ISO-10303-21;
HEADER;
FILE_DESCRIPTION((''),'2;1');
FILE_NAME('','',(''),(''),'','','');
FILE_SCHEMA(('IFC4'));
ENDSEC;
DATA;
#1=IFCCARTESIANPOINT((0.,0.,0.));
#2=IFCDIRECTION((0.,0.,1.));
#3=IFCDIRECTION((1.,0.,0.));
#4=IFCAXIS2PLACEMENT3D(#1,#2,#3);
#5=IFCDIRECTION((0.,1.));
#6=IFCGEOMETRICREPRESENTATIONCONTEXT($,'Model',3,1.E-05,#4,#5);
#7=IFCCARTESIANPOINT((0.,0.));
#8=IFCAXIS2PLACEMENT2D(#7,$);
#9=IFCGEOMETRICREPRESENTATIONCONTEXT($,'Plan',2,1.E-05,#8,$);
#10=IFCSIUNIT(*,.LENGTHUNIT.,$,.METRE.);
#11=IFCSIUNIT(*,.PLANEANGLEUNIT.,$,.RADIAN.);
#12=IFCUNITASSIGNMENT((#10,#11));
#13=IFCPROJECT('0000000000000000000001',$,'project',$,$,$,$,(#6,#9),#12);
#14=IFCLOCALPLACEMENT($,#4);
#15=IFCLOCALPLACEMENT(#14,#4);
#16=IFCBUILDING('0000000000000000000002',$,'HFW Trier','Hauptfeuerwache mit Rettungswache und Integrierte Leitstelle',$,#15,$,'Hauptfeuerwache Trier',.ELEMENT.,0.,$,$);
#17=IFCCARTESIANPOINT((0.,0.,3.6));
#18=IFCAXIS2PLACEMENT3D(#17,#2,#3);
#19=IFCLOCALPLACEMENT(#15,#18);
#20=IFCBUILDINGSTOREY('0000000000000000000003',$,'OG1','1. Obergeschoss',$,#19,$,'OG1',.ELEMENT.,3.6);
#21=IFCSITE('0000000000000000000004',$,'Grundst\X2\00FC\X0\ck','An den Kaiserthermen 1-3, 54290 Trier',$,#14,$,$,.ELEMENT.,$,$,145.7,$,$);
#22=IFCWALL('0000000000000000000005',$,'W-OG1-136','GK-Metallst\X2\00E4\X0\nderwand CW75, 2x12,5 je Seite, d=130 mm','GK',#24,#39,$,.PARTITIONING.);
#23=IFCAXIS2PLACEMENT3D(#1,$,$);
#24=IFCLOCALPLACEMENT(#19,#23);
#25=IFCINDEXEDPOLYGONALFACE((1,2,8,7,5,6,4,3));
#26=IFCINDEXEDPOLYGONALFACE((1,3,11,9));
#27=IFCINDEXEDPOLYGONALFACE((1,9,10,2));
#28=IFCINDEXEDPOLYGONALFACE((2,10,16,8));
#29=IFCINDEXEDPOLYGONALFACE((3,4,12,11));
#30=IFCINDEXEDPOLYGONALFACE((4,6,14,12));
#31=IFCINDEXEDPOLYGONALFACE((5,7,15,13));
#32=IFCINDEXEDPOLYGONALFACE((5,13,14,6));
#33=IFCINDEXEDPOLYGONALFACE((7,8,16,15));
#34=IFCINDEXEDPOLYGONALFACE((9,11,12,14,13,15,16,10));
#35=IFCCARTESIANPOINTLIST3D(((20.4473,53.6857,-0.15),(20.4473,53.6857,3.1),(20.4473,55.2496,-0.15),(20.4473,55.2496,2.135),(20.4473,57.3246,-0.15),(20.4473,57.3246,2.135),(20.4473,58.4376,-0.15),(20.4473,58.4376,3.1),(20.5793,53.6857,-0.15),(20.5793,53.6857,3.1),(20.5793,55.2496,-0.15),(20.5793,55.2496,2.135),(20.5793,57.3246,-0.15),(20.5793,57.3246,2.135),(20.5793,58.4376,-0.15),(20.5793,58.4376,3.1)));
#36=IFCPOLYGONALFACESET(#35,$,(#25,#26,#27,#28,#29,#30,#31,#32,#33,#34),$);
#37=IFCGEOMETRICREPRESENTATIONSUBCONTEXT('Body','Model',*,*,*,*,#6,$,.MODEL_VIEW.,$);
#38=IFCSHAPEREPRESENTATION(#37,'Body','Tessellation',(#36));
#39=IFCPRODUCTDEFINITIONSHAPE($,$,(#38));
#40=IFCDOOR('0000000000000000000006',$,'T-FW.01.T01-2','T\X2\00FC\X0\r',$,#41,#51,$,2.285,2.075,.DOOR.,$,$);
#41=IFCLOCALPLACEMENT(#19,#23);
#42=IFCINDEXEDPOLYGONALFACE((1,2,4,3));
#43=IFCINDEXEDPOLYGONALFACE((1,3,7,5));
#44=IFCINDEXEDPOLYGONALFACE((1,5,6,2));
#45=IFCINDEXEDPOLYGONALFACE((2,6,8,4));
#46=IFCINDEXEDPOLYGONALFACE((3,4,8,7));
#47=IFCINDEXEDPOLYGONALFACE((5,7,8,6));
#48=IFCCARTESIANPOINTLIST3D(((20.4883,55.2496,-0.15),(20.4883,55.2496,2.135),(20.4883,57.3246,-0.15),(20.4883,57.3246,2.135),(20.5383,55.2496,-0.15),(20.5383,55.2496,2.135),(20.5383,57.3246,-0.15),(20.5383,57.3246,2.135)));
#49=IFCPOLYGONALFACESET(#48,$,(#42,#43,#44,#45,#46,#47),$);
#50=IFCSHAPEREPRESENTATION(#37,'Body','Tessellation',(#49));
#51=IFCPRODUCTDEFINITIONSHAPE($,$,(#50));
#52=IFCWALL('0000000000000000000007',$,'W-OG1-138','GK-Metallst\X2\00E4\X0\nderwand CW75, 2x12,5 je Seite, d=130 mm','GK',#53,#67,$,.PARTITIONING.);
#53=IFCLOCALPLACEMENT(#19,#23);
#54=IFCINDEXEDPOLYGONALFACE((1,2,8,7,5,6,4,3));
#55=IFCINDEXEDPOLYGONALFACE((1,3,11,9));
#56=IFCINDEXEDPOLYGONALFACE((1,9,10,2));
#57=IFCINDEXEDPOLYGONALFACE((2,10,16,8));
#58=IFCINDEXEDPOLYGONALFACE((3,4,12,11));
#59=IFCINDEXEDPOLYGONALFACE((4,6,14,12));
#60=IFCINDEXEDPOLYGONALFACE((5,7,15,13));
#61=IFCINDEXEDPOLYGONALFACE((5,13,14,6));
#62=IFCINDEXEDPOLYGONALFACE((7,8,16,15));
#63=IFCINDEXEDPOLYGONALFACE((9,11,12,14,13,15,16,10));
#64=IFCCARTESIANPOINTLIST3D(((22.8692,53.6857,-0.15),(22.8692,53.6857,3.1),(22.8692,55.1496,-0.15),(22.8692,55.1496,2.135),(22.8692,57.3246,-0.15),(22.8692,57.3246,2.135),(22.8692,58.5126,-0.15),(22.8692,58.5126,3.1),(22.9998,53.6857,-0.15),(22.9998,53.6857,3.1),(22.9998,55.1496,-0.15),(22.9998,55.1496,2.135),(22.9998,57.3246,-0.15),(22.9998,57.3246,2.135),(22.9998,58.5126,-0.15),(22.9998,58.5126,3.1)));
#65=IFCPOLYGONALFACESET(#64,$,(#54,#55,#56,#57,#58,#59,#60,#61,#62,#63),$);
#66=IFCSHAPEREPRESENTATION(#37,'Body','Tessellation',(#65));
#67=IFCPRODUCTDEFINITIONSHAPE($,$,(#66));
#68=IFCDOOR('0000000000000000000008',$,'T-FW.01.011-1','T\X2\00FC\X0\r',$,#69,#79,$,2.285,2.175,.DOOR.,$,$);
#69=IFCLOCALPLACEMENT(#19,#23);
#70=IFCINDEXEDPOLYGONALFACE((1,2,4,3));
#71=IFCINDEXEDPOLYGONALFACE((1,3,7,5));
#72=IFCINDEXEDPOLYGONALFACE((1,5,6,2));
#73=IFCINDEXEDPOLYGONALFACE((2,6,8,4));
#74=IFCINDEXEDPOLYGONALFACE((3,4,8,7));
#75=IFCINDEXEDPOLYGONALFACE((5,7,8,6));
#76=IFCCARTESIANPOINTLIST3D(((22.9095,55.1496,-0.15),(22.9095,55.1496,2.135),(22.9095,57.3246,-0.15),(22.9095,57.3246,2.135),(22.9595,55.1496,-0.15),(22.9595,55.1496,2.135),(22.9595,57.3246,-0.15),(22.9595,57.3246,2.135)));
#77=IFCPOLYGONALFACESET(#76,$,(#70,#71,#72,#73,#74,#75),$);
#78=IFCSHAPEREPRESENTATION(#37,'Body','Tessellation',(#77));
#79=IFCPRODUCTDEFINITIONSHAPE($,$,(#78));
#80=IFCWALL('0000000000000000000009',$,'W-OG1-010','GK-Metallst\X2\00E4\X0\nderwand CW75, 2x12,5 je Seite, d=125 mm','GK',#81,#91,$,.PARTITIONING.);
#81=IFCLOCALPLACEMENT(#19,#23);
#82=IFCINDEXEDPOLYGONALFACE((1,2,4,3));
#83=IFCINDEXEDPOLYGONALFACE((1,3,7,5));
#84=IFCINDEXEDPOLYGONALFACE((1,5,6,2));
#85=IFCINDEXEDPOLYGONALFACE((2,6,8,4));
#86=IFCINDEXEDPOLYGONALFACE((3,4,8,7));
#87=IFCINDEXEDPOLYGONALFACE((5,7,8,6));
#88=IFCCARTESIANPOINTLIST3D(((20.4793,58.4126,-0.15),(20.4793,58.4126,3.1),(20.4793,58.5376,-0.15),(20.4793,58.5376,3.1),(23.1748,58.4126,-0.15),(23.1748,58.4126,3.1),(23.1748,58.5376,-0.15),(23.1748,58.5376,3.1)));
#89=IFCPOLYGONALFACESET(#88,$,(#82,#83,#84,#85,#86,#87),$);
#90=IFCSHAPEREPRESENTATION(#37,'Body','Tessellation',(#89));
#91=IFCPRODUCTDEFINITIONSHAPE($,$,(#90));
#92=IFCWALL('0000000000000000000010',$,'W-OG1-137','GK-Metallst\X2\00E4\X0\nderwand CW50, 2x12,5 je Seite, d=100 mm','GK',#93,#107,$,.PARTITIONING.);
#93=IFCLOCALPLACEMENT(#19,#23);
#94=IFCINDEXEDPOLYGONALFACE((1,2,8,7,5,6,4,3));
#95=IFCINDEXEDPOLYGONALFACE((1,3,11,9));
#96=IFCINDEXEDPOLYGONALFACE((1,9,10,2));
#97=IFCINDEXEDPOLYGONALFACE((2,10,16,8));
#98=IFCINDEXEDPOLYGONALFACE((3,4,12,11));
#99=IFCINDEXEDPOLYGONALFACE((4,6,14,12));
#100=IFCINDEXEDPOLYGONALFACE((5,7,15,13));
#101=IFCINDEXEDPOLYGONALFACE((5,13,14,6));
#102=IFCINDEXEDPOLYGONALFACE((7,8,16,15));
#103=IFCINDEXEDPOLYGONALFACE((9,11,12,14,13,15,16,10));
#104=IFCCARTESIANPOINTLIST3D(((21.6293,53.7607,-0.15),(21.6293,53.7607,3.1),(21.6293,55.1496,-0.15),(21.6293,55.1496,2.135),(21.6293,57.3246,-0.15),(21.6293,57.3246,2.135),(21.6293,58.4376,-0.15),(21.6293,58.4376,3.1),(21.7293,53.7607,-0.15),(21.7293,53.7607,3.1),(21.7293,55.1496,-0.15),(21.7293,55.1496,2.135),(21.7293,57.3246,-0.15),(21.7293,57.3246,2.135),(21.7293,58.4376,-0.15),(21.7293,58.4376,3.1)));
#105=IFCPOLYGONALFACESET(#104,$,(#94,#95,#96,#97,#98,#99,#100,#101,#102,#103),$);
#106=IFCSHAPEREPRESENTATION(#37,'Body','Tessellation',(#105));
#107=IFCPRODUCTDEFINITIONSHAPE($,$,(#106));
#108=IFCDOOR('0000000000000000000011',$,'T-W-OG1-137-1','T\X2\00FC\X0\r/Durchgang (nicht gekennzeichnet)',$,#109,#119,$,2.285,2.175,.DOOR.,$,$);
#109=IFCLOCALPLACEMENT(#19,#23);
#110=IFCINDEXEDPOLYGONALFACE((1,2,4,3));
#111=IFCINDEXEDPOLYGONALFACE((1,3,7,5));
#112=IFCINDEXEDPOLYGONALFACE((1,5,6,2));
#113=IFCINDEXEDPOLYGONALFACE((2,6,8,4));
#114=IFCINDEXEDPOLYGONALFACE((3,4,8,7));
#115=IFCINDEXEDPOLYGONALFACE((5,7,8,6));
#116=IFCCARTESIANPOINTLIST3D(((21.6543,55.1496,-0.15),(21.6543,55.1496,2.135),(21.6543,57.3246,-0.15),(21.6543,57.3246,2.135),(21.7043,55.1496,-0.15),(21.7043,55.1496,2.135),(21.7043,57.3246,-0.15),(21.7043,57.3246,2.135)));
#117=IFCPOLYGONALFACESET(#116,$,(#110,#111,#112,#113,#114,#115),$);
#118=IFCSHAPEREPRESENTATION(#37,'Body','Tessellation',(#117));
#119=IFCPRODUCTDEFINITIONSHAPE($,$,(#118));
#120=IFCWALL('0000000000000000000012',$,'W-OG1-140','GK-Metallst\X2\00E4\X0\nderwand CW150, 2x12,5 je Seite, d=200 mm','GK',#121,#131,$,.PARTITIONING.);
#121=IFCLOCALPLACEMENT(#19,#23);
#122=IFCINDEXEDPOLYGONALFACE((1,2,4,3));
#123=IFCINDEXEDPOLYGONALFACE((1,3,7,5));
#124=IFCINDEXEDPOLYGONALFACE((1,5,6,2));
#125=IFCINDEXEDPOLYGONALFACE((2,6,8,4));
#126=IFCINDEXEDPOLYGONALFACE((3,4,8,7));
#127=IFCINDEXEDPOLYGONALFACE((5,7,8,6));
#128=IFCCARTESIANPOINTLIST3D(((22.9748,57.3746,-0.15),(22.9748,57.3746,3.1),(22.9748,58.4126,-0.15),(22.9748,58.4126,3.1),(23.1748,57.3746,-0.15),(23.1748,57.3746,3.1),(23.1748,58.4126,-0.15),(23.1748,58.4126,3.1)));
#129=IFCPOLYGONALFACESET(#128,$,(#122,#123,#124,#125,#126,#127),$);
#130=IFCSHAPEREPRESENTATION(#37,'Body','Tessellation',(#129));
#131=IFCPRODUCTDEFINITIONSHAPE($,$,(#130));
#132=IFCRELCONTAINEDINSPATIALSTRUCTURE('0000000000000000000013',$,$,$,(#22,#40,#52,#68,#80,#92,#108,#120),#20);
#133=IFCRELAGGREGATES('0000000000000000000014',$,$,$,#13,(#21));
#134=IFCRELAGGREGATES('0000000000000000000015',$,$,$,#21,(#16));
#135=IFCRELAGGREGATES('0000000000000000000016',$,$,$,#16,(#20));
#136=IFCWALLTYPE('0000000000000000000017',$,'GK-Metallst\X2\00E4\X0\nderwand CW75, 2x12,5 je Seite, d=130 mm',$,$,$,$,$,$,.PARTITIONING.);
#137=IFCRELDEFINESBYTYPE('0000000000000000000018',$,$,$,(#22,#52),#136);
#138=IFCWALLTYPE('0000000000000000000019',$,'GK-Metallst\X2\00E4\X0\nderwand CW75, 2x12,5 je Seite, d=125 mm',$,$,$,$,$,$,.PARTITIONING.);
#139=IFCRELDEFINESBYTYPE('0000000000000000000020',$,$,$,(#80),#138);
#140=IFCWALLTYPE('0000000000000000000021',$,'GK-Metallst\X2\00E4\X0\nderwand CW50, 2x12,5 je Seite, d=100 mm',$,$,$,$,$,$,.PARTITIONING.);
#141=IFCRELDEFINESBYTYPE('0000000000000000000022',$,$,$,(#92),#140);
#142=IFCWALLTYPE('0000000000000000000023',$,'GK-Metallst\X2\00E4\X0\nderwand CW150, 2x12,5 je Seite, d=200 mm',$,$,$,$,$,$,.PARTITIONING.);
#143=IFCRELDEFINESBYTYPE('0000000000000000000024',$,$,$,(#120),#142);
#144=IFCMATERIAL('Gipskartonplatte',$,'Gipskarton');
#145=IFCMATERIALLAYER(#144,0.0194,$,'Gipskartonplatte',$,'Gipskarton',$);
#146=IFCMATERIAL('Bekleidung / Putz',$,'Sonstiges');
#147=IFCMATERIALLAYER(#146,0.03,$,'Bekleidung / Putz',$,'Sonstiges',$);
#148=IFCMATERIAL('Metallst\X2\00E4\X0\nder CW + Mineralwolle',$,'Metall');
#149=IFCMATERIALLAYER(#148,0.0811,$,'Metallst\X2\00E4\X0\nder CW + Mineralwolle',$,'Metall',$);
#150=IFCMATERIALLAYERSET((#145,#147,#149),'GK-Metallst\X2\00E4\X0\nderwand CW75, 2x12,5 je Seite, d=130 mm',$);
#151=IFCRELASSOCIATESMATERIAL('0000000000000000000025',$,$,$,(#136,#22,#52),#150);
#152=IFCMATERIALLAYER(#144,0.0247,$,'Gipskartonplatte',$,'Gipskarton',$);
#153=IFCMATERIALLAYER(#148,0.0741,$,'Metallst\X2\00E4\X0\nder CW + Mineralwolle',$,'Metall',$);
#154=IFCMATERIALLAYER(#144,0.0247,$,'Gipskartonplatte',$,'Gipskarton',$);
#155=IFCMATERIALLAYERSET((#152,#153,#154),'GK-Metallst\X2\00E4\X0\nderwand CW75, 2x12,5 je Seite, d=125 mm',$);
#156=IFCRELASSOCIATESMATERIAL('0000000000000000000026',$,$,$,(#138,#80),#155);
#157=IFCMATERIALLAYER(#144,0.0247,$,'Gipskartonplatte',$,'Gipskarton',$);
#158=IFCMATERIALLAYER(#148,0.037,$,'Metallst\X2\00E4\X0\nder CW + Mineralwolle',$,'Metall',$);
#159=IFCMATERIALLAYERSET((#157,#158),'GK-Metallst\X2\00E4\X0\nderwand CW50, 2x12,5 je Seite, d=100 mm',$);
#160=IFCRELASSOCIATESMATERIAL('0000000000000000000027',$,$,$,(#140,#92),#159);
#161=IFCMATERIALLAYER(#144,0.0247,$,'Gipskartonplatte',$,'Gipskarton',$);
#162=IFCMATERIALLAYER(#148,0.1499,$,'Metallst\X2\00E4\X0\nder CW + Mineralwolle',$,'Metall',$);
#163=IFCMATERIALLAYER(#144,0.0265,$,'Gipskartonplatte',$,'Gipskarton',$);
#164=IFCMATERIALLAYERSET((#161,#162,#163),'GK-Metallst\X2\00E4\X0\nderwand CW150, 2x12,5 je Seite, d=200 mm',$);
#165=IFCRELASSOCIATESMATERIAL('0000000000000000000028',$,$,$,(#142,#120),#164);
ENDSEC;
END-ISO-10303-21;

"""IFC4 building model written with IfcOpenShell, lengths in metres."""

from ifc_helpers import new_model, si_unit, direction, frame, frame_2d, origin_with_axes, origin_2d, place, context, subcontext, project, spatial, rectangle, extrude, material, layer, layer_set, layer_usage, type_object, element, fill, save


model = new_model("IFC4")

# Units and contexts
model_context = context("Model", 3, precision=1e-05, world=origin_with_axes(), true_north=direction((0.0, 1.0)))
plan_context = context("Plan", 2, precision=1e-05, world=origin_2d())
body_context = subcontext(model_context, "Body", "Model", "MODEL_VIEW")
ifc_project = project(units=[si_unit("LENGTHUNIT", "METRE"), si_unit("PLANEANGLEUNIT", "RADIAN")], contexts=[model_context, plan_context])

# Site, building, storey
site_placement = place(None, origin_with_axes())
site = spatial("IfcSite", under=ifc_project, at=site_placement, Name="Grundstück", Description="An den Kaiserthermen 1-3, 54290 Trier", CompositionType="ELEMENT", RefElevation=145.7)
building_placement = place(site_placement, origin_with_axes())
building = spatial("IfcBuilding", under=site, at=building_placement, Name="HFW Trier", Description="Hauptfeuerwache mit Rettungswache und Integrierte Leitstelle", LongName="Hauptfeuerwache Trier", CompositionType="ELEMENT", ElevationOfRefHeight=0.0)
storey_placement = place(building_placement, frame((0.0, 0.0, 3.6), z_axis=(0.0, 0.0, 1.0), x_axis=(1.0, 0.0, 0.0)))
storey = spatial("IfcBuildingStorey", under=building, at=storey_placement, Name="OG1", Description="1. Obergeschoss", LongName="OG1", CompositionType="ELEMENT", Elevation=3.6)

# Walls, openings, doors
ifc_material_1 = material(Name="Gipskartonplatte", Category="Gipskarton")
ifc_layer_1 = layer(ifc_material_1, 0.0194, Name="Gipskartonplatte", Category="Gipskarton")
ifc_material_2 = material(Name="Bekleidung / Putz", Category="Sonstiges")
ifc_layer_2 = layer(ifc_material_2, 0.03, Name="Bekleidung / Putz", Category="Sonstiges")
ifc_material_3 = material(Name="Metallständer CW + Mineralwolle", Category="Metall")
ifc_layer_3 = layer(ifc_material_3, 0.0811, Name="Metallständer CW + Mineralwolle", Category="Metall")
ifc_layer_set_1 = layer_set([ifc_layer_1, ifc_layer_2, ifc_layer_3], Name="GK-Metallständerwand CW75, 2x12,5 je Seite, d=130 mm")
ifc_layer_usage_1 = layer_usage(ifc_layer_set_1, "AXIS2", "POSITIVE", -0.066)
wall_type_1 = type_object("IfcWallType", Name="GK-Metallständerwand CW75, 2x12,5 je Seite, d=130 mm", PredefinedType="PARTITIONING", material=ifc_layer_set_1)
wall_1_placement = place(storey_placement, frame((20.5133, 58.4376, -0.15), z_axis=(0.0, 0.0, 1.0), x_axis=(0.0, -1.0, 0.0)))
wall_1 = element("IfcWall", 1, at=wall_1_placement, inside=storey, type_object=wall_type_1, material=ifc_layer_usage_1, Name="W-OG1-136", Description="GK-Metallständerwand CW75, 2x12,5 je Seite, d=130 mm", ObjectType="GK", PredefinedType="PARTITIONING", context=body_context, shape_type="SweptSolid", body=[
    extrude(rectangle(XDim=4.7519, YDim=0.132, at=frame_2d((2.376, 0.0))), origin_with_axes(), (0.0, 0.0, 1.0), 3.25),
])
opening_1_placement = place(wall_1_placement, frame((1.113, 0.0, 0.0), z_axis=(0.0, 0.0, 1.0), x_axis=(1.0, 0.0, 0.0)))
opening_1 = element("IfcOpeningElement", 2, at=opening_1_placement, cuts=wall_1, PredefinedType="OPENING", context=body_context, shape_type="SweptSolid", body=[
    extrude(rectangle(XDim=2.075, YDim=0.232, at=frame_2d((1.0375, 0.0))), origin_with_axes(), (0.0, 0.0, 1.0), 2.285),
])
door_1_placement = place(wall_1_placement, frame((1.113, 0.0, 0.0), z_axis=(0.0, 0.0, 1.0), x_axis=(1.0, 0.0, 0.0)))
door_1 = element("IfcDoor", 3, at=door_1_placement, inside=storey, Name="T-FW.01.T01-2", Description="Tür", OverallHeight=2.285, OverallWidth=2.075, PredefinedType="DOOR", context=body_context, shape_type="SweptSolid", body=[
    extrude(rectangle(XDim=2.075, YDim=0.05, at=frame_2d((1.0375, 0.0))), origin_with_axes(), (0.0, 0.0, 1.0), 2.285),
])
fill(opening_1, door_1)
ifc_layer_usage_2 = layer_usage(ifc_layer_set_1, "AXIS2", "POSITIVE", -0.0653)
wall_2_placement = place(storey_placement, frame((22.9345, 58.5126, -0.15), z_axis=(0.0, 0.0, 1.0), x_axis=(0.0, -1.0, 0.0)))
wall_2 = element("IfcWall", 4, at=wall_2_placement, inside=storey, type_object=wall_type_1, material=ifc_layer_usage_2, Name="W-OG1-138", Description="GK-Metallständerwand CW75, 2x12,5 je Seite, d=130 mm", ObjectType="GK", PredefinedType="PARTITIONING", context=body_context, shape_type="SweptSolid", body=[
    extrude(rectangle(XDim=4.8269, YDim=0.1305, at=frame_2d((2.4135, 0.0))), origin_with_axes(), (0.0, 0.0, 1.0), 3.25),
])
opening_2_placement = place(wall_2_placement, frame((1.188, 0.0, 0.0), z_axis=(0.0, 0.0, 1.0), x_axis=(1.0, 0.0, 0.0)))
opening_2 = element("IfcOpeningElement", 5, at=opening_2_placement, cuts=wall_2, PredefinedType="OPENING", context=body_context, shape_type="SweptSolid", body=[
    extrude(rectangle(XDim=2.175, YDim=0.2305, at=frame_2d((1.0875, 0.0))), origin_with_axes(), (0.0, 0.0, 1.0), 2.285),
])
door_2_placement = place(wall_2_placement, frame((1.188, 0.0, 0.0), z_axis=(0.0, 0.0, 1.0), x_axis=(1.0, 0.0, 0.0)))
door_2 = element("IfcDoor", 6, at=door_2_placement, inside=storey, Name="T-FW.01.011-1", Description="Tür", OverallHeight=2.285, OverallWidth=2.175, PredefinedType="DOOR", context=body_context, shape_type="SweptSolid", body=[
    extrude(rectangle(XDim=2.175, YDim=0.05, at=frame_2d((1.0875, 0.0))), origin_with_axes(), (0.0, 0.0, 1.0), 2.285),
])
fill(opening_2, door_2)

# Wall
ifc_layer_4 = layer(ifc_material_1, 0.0247, Name="Gipskartonplatte", Category="Gipskarton")
ifc_layer_5 = layer(ifc_material_3, 0.0741, Name="Metallständer CW + Mineralwolle", Category="Metall")
ifc_layer_6 = layer(ifc_material_1, 0.0247, Name="Gipskartonplatte", Category="Gipskarton")
ifc_layer_set_2 = layer_set([ifc_layer_4, ifc_layer_5, ifc_layer_6], Name="GK-Metallständerwand CW75, 2x12,5 je Seite, d=125 mm")
ifc_layer_usage_3 = layer_usage(ifc_layer_set_2, "AXIS2", "POSITIVE", -0.0625)
wall_type_2 = type_object("IfcWallType", Name="GK-Metallständerwand CW75, 2x12,5 je Seite, d=125 mm", PredefinedType="PARTITIONING", material=ifc_layer_set_2)
wall_3_placement = place(storey_placement, frame((20.4793, 58.4751, -0.15), z_axis=(0.0, 0.0, 1.0), x_axis=(1.0, 0.0, 0.0)))
element("IfcWall", 7, at=wall_3_placement, inside=storey, type_object=wall_type_2, material=ifc_layer_usage_3, Name="W-OG1-010", Description="GK-Metallständerwand CW75, 2x12,5 je Seite, d=125 mm", ObjectType="GK", PredefinedType="PARTITIONING", context=body_context, shape_type="SweptSolid", body=[
    extrude(rectangle(XDim=2.6955, YDim=0.125, at=frame_2d((1.3478, 0.0))), origin_with_axes(), (0.0, 0.0, 1.0), 3.25),
])

# Wall, opening, door
ifc_layer_7 = layer(ifc_material_1, 0.0247, Name="Gipskartonplatte", Category="Gipskarton")
ifc_layer_8 = layer(ifc_material_3, 0.037, Name="Metallständer CW + Mineralwolle", Category="Metall")
ifc_layer_set_3 = layer_set([ifc_layer_7, ifc_layer_8], Name="GK-Metallständerwand CW50, 2x12,5 je Seite, d=100 mm")
ifc_layer_usage_4 = layer_usage(ifc_layer_set_3, "AXIS2", "POSITIVE", -0.05)
wall_type_3 = type_object("IfcWallType", Name="GK-Metallständerwand CW50, 2x12,5 je Seite, d=100 mm", PredefinedType="PARTITIONING", material=ifc_layer_set_3)
wall_4_placement = place(storey_placement, frame((21.6793, 58.4376, -0.15), z_axis=(0.0, 0.0, 1.0), x_axis=(0.0, -1.0, 0.0)))
wall_4 = element("IfcWall", 8, at=wall_4_placement, inside=storey, type_object=wall_type_3, material=ifc_layer_usage_4, Name="W-OG1-137", Description="GK-Metallständerwand CW50, 2x12,5 je Seite, d=100 mm", ObjectType="GK", PredefinedType="PARTITIONING", context=body_context, shape_type="SweptSolid", body=[
    extrude(rectangle(XDim=4.6769, YDim=0.1, at=frame_2d((2.3385, 0.0))), origin_with_axes(), (0.0, 0.0, 1.0), 3.25),
])
opening_3_placement = place(wall_4_placement, frame((1.113, 0.0, 0.0), z_axis=(0.0, 0.0, 1.0), x_axis=(1.0, 0.0, 0.0)))
opening_3 = element("IfcOpeningElement", 9, at=opening_3_placement, cuts=wall_4, PredefinedType="OPENING", context=body_context, shape_type="SweptSolid", body=[
    extrude(rectangle(XDim=2.175, YDim=0.2, at=frame_2d((1.0875, 0.0))), origin_with_axes(), (0.0, 0.0, 1.0), 2.285),
])
door_3_placement = place(wall_4_placement, frame((1.113, 0.0, 0.0), z_axis=(0.0, 0.0, 1.0), x_axis=(1.0, 0.0, 0.0)))
door_3 = element("IfcDoor", 10, at=door_3_placement, inside=storey, Name="T-W-OG1-137-1", Description="Tür/Durchgang (nicht gekennzeichnet)", OverallHeight=2.285, OverallWidth=2.175, PredefinedType="DOOR", context=body_context, shape_type="SweptSolid", body=[
    extrude(rectangle(XDim=2.175, YDim=0.05, at=frame_2d((1.0875, 0.0))), origin_with_axes(), (0.0, 0.0, 1.0), 2.285),
])
fill(opening_3, door_3)

# Wall
ifc_layer_9 = layer(ifc_material_1, 0.0247, Name="Gipskartonplatte", Category="Gipskarton")
ifc_layer_10 = layer(ifc_material_3, 0.1499, Name="Metallständer CW + Mineralwolle", Category="Metall")
ifc_layer_11 = layer(ifc_material_1, 0.0265, Name="Gipskartonplatte", Category="Gipskarton")
ifc_layer_set_4 = layer_set([ifc_layer_9, ifc_layer_10, ifc_layer_11], Name="GK-Metallständerwand CW150, 2x12,5 je Seite, d=200 mm")
ifc_layer_usage_5 = layer_usage(ifc_layer_set_4, "AXIS2", "POSITIVE", -0.1)
wall_type_4 = type_object("IfcWallType", Name="GK-Metallständerwand CW150, 2x12,5 je Seite, d=200 mm", PredefinedType="PARTITIONING", material=ifc_layer_set_4)
wall_5_placement = place(storey_placement, frame((23.0748, 58.4126, -0.15), z_axis=(0.0, 0.0, 1.0), x_axis=(0.0, -1.0, 0.0)))
element("IfcWall", 11, at=wall_5_placement, inside=storey, type_object=wall_type_4, material=ifc_layer_usage_5, Name="W-OG1-140", Description="GK-Metallständerwand CW150, 2x12,5 je Seite, d=200 mm", ObjectType="GK", PredefinedType="PARTITIONING", context=body_context, shape_type="SweptSolid", body=[
    extrude(rectangle(XDim=1.038, YDim=0.2, at=frame_2d((0.519, 0.0))), origin_with_axes(), (0.0, 0.0, 1.0), 3.25),
])

save(model, "model.ifc")
